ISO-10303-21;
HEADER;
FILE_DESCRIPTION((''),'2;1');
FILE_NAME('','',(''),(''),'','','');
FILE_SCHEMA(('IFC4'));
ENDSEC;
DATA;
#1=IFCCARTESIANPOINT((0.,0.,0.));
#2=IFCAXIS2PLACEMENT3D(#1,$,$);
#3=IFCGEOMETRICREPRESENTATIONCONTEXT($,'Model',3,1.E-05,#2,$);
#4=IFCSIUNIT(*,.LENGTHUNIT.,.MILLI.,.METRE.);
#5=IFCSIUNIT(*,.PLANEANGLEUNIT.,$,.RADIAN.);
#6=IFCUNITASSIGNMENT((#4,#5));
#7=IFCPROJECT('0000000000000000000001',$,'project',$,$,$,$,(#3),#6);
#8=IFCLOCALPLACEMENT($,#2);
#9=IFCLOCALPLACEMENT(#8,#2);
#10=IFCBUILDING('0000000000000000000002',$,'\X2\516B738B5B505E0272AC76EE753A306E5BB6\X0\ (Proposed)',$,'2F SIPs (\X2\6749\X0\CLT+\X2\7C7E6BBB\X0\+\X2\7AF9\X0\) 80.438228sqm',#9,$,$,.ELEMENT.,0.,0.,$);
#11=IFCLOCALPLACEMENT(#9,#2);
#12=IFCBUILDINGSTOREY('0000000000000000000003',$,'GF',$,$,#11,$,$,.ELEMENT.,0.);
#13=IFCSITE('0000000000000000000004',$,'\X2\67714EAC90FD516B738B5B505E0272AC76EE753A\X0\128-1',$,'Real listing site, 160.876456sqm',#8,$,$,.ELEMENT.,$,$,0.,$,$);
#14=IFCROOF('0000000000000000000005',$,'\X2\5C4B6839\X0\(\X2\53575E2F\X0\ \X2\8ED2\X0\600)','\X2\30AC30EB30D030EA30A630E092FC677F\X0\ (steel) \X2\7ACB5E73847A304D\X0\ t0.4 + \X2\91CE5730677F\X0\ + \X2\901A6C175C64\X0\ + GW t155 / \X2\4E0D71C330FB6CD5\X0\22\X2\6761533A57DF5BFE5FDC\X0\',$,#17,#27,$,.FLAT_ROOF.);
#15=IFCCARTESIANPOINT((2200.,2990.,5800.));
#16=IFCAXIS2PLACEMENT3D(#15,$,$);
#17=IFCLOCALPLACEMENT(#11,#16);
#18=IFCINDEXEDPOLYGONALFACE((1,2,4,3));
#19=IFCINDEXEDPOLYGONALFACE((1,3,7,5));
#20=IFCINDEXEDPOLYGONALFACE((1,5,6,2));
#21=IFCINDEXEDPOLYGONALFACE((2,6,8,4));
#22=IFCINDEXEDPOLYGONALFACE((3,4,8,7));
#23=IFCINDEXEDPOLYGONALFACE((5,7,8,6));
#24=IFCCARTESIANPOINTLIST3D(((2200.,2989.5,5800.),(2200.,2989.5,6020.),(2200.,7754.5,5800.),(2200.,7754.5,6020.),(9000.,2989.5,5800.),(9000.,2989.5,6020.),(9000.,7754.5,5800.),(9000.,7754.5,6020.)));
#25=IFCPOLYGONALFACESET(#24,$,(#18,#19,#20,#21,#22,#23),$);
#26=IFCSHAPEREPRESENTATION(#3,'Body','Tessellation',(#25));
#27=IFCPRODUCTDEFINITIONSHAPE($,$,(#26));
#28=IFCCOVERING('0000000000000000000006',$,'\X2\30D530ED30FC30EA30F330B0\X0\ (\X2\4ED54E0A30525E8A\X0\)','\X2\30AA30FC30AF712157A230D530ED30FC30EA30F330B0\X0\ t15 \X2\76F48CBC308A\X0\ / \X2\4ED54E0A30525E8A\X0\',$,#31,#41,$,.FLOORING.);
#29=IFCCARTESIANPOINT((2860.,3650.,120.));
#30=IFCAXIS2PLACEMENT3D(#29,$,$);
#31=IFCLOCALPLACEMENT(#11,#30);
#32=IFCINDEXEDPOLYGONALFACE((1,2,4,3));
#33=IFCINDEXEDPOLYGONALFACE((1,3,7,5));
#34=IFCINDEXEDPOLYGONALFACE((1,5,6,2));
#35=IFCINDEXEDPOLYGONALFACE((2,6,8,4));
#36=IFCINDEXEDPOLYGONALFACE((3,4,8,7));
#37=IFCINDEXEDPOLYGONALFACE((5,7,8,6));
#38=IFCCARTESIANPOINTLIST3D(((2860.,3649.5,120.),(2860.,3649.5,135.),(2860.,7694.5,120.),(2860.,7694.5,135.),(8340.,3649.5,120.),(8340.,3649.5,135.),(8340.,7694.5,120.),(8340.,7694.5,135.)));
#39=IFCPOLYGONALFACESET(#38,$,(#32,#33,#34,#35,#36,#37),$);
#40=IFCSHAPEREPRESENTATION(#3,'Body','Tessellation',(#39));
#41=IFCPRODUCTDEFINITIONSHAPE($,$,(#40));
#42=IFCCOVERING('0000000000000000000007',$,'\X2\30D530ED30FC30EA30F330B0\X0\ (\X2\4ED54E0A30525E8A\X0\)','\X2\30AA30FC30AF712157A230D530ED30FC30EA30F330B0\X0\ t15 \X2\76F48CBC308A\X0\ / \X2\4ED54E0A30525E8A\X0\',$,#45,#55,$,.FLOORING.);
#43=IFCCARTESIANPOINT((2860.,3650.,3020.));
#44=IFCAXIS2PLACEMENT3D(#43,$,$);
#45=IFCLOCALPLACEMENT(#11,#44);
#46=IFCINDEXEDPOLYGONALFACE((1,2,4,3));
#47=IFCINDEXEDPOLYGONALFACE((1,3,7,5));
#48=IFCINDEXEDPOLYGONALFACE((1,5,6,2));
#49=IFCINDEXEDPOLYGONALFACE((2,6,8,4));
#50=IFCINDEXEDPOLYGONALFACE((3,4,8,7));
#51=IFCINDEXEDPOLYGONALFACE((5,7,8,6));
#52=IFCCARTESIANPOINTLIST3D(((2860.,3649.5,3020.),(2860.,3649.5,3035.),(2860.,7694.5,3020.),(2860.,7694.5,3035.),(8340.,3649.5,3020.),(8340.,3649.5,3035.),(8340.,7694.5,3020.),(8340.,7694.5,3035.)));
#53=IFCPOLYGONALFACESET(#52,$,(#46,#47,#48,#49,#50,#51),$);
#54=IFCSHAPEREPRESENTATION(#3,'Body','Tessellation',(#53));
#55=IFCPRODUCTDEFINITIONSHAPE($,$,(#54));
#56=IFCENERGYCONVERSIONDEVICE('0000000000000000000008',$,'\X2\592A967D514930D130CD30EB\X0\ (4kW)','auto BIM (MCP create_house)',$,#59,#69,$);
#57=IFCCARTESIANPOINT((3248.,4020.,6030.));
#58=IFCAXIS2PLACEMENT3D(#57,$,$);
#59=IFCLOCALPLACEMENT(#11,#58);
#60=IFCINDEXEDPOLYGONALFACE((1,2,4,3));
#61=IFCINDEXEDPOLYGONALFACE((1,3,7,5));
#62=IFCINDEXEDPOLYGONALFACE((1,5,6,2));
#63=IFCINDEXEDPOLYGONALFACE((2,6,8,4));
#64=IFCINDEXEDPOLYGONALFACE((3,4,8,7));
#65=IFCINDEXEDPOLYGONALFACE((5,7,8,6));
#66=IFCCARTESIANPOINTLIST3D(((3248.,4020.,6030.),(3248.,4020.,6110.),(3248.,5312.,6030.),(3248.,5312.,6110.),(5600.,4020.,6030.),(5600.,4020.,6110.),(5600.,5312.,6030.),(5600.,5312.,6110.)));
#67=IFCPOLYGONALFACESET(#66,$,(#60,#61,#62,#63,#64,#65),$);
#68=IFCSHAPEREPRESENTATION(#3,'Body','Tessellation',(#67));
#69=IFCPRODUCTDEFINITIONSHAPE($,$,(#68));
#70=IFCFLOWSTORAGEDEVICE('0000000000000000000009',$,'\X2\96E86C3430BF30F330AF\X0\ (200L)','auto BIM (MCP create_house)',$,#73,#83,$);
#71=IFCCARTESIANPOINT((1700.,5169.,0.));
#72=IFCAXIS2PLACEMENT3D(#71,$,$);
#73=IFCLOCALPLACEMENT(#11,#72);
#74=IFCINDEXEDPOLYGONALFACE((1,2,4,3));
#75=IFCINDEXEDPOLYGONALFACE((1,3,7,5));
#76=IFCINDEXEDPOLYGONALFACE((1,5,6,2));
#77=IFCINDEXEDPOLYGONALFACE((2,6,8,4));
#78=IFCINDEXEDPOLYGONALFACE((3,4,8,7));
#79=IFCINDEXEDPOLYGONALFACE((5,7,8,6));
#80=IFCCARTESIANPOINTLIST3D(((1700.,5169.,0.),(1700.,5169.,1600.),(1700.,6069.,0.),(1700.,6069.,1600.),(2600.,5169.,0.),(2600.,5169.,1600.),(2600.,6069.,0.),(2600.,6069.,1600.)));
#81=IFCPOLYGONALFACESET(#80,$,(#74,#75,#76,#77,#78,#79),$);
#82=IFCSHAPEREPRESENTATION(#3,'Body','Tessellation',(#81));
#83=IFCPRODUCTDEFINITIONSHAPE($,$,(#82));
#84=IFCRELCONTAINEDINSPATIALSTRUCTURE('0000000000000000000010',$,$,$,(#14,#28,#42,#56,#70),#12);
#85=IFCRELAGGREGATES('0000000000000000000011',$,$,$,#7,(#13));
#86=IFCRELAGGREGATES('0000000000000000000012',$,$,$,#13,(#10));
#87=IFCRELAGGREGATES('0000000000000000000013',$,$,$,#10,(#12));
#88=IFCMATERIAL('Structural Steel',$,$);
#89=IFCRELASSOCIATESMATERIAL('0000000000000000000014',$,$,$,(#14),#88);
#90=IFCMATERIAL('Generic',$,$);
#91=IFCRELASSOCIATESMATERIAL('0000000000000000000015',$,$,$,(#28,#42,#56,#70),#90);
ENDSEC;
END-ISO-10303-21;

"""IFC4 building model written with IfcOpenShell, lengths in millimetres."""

from ifc_helpers import new_model, si_unit, frame, frame_2d, origin, place, context, project, spatial, rectangle, extrude, material, element, save


model = new_model("IFC4")

# Units and contexts
model_context = context("Model", 3, precision=1e-05, world=origin())
ifc_project = project(units=[si_unit("LENGTHUNIT", "METRE", prefix="MILLI"), si_unit("PLANEANGLEUNIT", "RADIAN")], contexts=[model_context])

# Site, building, storey
site_placement = place(None, origin())
site = spatial("IfcSite", under=ifc_project, at=site_placement, Name="東京都八王子市犬目町128-1", ObjectType="Real listing site, 160.876456sqm", CompositionType="ELEMENT", RefElevation=0.0)
building_placement = place(site_placement, origin())
building = spatial("IfcBuilding", under=site, at=building_placement, Name="八王子市犬目町の家 (Proposed)", ObjectType="2F SIPs (杉CLT+籾殻+竹) 80.438228sqm", CompositionType="ELEMENT", ElevationOfRefHeight=0.0, ElevationOfTerrain=0.0)
storey_placement = place(building_placement, origin())
storey = spatial("IfcBuildingStorey", under=building, at=storey_placement, Name="GF", CompositionType="ELEMENT", Elevation=0.0)

# Roof
ifc_material_1 = material(Name="Structural Steel")
for number, where, name in (
    (1, (2200.0, 2990.0, 5800.0), "屋根(南帯 軒600)"),
):
    element("IfcRoof", number, at=place(storey_placement, frame(where)), inside=storey, material=ifc_material_1, Name=name, Description="ガルバリウム鋼板 (steel) 立平葺き t0.4 + 野地板 + 通気層 + GW t155 / 不燃・法22条区域対応", PredefinedType="FLAT_ROOF", context=model_context, shape_type="SweptSolid", body=[
        extrude(rectangle(XDim=6800.0, YDim=4765.0, at=frame_2d((3400.0, 2382.0))), frame((2200.0, 2990.0, 5800.0)), (0.0, 0.0, 1.0), 220.0),
    ])

# Coverings
ifc_material_2 = material(Name="Generic")
covering_1_placement = place(storey_placement, frame((2860.0, 3650.0, 120.0)))
element("IfcCovering", 2, at=covering_1_placement, inside=storey, material=ifc_material_2, Name="フローリング (仕上げ床)", Description="オーク無垢フローリング t15 直貼り / 仕上げ床", PredefinedType="FLOORING", context=model_context, shape_type="SweptSolid", body=[
    extrude(rectangle(XDim=5480.0, YDim=4045.0, at=frame_2d((2740.0, 2022.0))), frame((2860.0, 3650.0, 120.0)), (0.0, 0.0, 1.0), 15.0),
])
covering_2_placement = place(storey_placement, frame((2860.0, 3650.0, 3020.0)))
element("IfcCovering", 3, at=covering_2_placement, inside=storey, material=ifc_material_2, Name="フローリング (仕上げ床)", Description="オーク無垢フローリング t15 直貼り / 仕上げ床", PredefinedType="FLOORING", context=model_context, shape_type="SweptSolid", body=[
    extrude(rectangle(XDim=5480.0, YDim=4045.0, at=frame_2d((2740.0, 2022.0))), frame((2860.0, 3650.0, 3020.0)), (0.0, 0.0, 1.0), 15.0),
])

# Energy conversion device
energy_conversion_device_placement = place(storey_placement, frame((3248.0, 4020.0, 6030.0)))
element("IfcEnergyConversionDevice", 4, at=energy_conversion_device_placement, inside=storey, material=ifc_material_2, Name="太陽光パネル (4kW)", Description="auto BIM (MCP create_house)", context=model_context, shape_type="SweptSolid", body=[
    extrude(rectangle(XDim=2352.0, YDim=1292.0, at=frame_2d((1176.0, 646.0))), frame((3248.0, 4020.0, 6030.0)), (0.0, 0.0, 1.0), 80.0),
])

# Flow storage device
flow_storage_device_placement = place(storey_placement, frame((1700.0, 5169.0, 0.0)))
element("IfcFlowStorageDevice", 5, at=flow_storage_device_placement, inside=storey, material=ifc_material_2, Name="雨水タンク (200L)", Description="auto BIM (MCP create_house)", context=model_context, shape_type="SweptSolid", body=[
    extrude(rectangle(XDim=900.0, YDim=900.0, at=frame_2d((450.0, 450.0))), frame((1700.0, 5169.0, 0.0)), (0.0, 0.0, 1.0), 1600.0),
])

save(model, "model.ifc")
